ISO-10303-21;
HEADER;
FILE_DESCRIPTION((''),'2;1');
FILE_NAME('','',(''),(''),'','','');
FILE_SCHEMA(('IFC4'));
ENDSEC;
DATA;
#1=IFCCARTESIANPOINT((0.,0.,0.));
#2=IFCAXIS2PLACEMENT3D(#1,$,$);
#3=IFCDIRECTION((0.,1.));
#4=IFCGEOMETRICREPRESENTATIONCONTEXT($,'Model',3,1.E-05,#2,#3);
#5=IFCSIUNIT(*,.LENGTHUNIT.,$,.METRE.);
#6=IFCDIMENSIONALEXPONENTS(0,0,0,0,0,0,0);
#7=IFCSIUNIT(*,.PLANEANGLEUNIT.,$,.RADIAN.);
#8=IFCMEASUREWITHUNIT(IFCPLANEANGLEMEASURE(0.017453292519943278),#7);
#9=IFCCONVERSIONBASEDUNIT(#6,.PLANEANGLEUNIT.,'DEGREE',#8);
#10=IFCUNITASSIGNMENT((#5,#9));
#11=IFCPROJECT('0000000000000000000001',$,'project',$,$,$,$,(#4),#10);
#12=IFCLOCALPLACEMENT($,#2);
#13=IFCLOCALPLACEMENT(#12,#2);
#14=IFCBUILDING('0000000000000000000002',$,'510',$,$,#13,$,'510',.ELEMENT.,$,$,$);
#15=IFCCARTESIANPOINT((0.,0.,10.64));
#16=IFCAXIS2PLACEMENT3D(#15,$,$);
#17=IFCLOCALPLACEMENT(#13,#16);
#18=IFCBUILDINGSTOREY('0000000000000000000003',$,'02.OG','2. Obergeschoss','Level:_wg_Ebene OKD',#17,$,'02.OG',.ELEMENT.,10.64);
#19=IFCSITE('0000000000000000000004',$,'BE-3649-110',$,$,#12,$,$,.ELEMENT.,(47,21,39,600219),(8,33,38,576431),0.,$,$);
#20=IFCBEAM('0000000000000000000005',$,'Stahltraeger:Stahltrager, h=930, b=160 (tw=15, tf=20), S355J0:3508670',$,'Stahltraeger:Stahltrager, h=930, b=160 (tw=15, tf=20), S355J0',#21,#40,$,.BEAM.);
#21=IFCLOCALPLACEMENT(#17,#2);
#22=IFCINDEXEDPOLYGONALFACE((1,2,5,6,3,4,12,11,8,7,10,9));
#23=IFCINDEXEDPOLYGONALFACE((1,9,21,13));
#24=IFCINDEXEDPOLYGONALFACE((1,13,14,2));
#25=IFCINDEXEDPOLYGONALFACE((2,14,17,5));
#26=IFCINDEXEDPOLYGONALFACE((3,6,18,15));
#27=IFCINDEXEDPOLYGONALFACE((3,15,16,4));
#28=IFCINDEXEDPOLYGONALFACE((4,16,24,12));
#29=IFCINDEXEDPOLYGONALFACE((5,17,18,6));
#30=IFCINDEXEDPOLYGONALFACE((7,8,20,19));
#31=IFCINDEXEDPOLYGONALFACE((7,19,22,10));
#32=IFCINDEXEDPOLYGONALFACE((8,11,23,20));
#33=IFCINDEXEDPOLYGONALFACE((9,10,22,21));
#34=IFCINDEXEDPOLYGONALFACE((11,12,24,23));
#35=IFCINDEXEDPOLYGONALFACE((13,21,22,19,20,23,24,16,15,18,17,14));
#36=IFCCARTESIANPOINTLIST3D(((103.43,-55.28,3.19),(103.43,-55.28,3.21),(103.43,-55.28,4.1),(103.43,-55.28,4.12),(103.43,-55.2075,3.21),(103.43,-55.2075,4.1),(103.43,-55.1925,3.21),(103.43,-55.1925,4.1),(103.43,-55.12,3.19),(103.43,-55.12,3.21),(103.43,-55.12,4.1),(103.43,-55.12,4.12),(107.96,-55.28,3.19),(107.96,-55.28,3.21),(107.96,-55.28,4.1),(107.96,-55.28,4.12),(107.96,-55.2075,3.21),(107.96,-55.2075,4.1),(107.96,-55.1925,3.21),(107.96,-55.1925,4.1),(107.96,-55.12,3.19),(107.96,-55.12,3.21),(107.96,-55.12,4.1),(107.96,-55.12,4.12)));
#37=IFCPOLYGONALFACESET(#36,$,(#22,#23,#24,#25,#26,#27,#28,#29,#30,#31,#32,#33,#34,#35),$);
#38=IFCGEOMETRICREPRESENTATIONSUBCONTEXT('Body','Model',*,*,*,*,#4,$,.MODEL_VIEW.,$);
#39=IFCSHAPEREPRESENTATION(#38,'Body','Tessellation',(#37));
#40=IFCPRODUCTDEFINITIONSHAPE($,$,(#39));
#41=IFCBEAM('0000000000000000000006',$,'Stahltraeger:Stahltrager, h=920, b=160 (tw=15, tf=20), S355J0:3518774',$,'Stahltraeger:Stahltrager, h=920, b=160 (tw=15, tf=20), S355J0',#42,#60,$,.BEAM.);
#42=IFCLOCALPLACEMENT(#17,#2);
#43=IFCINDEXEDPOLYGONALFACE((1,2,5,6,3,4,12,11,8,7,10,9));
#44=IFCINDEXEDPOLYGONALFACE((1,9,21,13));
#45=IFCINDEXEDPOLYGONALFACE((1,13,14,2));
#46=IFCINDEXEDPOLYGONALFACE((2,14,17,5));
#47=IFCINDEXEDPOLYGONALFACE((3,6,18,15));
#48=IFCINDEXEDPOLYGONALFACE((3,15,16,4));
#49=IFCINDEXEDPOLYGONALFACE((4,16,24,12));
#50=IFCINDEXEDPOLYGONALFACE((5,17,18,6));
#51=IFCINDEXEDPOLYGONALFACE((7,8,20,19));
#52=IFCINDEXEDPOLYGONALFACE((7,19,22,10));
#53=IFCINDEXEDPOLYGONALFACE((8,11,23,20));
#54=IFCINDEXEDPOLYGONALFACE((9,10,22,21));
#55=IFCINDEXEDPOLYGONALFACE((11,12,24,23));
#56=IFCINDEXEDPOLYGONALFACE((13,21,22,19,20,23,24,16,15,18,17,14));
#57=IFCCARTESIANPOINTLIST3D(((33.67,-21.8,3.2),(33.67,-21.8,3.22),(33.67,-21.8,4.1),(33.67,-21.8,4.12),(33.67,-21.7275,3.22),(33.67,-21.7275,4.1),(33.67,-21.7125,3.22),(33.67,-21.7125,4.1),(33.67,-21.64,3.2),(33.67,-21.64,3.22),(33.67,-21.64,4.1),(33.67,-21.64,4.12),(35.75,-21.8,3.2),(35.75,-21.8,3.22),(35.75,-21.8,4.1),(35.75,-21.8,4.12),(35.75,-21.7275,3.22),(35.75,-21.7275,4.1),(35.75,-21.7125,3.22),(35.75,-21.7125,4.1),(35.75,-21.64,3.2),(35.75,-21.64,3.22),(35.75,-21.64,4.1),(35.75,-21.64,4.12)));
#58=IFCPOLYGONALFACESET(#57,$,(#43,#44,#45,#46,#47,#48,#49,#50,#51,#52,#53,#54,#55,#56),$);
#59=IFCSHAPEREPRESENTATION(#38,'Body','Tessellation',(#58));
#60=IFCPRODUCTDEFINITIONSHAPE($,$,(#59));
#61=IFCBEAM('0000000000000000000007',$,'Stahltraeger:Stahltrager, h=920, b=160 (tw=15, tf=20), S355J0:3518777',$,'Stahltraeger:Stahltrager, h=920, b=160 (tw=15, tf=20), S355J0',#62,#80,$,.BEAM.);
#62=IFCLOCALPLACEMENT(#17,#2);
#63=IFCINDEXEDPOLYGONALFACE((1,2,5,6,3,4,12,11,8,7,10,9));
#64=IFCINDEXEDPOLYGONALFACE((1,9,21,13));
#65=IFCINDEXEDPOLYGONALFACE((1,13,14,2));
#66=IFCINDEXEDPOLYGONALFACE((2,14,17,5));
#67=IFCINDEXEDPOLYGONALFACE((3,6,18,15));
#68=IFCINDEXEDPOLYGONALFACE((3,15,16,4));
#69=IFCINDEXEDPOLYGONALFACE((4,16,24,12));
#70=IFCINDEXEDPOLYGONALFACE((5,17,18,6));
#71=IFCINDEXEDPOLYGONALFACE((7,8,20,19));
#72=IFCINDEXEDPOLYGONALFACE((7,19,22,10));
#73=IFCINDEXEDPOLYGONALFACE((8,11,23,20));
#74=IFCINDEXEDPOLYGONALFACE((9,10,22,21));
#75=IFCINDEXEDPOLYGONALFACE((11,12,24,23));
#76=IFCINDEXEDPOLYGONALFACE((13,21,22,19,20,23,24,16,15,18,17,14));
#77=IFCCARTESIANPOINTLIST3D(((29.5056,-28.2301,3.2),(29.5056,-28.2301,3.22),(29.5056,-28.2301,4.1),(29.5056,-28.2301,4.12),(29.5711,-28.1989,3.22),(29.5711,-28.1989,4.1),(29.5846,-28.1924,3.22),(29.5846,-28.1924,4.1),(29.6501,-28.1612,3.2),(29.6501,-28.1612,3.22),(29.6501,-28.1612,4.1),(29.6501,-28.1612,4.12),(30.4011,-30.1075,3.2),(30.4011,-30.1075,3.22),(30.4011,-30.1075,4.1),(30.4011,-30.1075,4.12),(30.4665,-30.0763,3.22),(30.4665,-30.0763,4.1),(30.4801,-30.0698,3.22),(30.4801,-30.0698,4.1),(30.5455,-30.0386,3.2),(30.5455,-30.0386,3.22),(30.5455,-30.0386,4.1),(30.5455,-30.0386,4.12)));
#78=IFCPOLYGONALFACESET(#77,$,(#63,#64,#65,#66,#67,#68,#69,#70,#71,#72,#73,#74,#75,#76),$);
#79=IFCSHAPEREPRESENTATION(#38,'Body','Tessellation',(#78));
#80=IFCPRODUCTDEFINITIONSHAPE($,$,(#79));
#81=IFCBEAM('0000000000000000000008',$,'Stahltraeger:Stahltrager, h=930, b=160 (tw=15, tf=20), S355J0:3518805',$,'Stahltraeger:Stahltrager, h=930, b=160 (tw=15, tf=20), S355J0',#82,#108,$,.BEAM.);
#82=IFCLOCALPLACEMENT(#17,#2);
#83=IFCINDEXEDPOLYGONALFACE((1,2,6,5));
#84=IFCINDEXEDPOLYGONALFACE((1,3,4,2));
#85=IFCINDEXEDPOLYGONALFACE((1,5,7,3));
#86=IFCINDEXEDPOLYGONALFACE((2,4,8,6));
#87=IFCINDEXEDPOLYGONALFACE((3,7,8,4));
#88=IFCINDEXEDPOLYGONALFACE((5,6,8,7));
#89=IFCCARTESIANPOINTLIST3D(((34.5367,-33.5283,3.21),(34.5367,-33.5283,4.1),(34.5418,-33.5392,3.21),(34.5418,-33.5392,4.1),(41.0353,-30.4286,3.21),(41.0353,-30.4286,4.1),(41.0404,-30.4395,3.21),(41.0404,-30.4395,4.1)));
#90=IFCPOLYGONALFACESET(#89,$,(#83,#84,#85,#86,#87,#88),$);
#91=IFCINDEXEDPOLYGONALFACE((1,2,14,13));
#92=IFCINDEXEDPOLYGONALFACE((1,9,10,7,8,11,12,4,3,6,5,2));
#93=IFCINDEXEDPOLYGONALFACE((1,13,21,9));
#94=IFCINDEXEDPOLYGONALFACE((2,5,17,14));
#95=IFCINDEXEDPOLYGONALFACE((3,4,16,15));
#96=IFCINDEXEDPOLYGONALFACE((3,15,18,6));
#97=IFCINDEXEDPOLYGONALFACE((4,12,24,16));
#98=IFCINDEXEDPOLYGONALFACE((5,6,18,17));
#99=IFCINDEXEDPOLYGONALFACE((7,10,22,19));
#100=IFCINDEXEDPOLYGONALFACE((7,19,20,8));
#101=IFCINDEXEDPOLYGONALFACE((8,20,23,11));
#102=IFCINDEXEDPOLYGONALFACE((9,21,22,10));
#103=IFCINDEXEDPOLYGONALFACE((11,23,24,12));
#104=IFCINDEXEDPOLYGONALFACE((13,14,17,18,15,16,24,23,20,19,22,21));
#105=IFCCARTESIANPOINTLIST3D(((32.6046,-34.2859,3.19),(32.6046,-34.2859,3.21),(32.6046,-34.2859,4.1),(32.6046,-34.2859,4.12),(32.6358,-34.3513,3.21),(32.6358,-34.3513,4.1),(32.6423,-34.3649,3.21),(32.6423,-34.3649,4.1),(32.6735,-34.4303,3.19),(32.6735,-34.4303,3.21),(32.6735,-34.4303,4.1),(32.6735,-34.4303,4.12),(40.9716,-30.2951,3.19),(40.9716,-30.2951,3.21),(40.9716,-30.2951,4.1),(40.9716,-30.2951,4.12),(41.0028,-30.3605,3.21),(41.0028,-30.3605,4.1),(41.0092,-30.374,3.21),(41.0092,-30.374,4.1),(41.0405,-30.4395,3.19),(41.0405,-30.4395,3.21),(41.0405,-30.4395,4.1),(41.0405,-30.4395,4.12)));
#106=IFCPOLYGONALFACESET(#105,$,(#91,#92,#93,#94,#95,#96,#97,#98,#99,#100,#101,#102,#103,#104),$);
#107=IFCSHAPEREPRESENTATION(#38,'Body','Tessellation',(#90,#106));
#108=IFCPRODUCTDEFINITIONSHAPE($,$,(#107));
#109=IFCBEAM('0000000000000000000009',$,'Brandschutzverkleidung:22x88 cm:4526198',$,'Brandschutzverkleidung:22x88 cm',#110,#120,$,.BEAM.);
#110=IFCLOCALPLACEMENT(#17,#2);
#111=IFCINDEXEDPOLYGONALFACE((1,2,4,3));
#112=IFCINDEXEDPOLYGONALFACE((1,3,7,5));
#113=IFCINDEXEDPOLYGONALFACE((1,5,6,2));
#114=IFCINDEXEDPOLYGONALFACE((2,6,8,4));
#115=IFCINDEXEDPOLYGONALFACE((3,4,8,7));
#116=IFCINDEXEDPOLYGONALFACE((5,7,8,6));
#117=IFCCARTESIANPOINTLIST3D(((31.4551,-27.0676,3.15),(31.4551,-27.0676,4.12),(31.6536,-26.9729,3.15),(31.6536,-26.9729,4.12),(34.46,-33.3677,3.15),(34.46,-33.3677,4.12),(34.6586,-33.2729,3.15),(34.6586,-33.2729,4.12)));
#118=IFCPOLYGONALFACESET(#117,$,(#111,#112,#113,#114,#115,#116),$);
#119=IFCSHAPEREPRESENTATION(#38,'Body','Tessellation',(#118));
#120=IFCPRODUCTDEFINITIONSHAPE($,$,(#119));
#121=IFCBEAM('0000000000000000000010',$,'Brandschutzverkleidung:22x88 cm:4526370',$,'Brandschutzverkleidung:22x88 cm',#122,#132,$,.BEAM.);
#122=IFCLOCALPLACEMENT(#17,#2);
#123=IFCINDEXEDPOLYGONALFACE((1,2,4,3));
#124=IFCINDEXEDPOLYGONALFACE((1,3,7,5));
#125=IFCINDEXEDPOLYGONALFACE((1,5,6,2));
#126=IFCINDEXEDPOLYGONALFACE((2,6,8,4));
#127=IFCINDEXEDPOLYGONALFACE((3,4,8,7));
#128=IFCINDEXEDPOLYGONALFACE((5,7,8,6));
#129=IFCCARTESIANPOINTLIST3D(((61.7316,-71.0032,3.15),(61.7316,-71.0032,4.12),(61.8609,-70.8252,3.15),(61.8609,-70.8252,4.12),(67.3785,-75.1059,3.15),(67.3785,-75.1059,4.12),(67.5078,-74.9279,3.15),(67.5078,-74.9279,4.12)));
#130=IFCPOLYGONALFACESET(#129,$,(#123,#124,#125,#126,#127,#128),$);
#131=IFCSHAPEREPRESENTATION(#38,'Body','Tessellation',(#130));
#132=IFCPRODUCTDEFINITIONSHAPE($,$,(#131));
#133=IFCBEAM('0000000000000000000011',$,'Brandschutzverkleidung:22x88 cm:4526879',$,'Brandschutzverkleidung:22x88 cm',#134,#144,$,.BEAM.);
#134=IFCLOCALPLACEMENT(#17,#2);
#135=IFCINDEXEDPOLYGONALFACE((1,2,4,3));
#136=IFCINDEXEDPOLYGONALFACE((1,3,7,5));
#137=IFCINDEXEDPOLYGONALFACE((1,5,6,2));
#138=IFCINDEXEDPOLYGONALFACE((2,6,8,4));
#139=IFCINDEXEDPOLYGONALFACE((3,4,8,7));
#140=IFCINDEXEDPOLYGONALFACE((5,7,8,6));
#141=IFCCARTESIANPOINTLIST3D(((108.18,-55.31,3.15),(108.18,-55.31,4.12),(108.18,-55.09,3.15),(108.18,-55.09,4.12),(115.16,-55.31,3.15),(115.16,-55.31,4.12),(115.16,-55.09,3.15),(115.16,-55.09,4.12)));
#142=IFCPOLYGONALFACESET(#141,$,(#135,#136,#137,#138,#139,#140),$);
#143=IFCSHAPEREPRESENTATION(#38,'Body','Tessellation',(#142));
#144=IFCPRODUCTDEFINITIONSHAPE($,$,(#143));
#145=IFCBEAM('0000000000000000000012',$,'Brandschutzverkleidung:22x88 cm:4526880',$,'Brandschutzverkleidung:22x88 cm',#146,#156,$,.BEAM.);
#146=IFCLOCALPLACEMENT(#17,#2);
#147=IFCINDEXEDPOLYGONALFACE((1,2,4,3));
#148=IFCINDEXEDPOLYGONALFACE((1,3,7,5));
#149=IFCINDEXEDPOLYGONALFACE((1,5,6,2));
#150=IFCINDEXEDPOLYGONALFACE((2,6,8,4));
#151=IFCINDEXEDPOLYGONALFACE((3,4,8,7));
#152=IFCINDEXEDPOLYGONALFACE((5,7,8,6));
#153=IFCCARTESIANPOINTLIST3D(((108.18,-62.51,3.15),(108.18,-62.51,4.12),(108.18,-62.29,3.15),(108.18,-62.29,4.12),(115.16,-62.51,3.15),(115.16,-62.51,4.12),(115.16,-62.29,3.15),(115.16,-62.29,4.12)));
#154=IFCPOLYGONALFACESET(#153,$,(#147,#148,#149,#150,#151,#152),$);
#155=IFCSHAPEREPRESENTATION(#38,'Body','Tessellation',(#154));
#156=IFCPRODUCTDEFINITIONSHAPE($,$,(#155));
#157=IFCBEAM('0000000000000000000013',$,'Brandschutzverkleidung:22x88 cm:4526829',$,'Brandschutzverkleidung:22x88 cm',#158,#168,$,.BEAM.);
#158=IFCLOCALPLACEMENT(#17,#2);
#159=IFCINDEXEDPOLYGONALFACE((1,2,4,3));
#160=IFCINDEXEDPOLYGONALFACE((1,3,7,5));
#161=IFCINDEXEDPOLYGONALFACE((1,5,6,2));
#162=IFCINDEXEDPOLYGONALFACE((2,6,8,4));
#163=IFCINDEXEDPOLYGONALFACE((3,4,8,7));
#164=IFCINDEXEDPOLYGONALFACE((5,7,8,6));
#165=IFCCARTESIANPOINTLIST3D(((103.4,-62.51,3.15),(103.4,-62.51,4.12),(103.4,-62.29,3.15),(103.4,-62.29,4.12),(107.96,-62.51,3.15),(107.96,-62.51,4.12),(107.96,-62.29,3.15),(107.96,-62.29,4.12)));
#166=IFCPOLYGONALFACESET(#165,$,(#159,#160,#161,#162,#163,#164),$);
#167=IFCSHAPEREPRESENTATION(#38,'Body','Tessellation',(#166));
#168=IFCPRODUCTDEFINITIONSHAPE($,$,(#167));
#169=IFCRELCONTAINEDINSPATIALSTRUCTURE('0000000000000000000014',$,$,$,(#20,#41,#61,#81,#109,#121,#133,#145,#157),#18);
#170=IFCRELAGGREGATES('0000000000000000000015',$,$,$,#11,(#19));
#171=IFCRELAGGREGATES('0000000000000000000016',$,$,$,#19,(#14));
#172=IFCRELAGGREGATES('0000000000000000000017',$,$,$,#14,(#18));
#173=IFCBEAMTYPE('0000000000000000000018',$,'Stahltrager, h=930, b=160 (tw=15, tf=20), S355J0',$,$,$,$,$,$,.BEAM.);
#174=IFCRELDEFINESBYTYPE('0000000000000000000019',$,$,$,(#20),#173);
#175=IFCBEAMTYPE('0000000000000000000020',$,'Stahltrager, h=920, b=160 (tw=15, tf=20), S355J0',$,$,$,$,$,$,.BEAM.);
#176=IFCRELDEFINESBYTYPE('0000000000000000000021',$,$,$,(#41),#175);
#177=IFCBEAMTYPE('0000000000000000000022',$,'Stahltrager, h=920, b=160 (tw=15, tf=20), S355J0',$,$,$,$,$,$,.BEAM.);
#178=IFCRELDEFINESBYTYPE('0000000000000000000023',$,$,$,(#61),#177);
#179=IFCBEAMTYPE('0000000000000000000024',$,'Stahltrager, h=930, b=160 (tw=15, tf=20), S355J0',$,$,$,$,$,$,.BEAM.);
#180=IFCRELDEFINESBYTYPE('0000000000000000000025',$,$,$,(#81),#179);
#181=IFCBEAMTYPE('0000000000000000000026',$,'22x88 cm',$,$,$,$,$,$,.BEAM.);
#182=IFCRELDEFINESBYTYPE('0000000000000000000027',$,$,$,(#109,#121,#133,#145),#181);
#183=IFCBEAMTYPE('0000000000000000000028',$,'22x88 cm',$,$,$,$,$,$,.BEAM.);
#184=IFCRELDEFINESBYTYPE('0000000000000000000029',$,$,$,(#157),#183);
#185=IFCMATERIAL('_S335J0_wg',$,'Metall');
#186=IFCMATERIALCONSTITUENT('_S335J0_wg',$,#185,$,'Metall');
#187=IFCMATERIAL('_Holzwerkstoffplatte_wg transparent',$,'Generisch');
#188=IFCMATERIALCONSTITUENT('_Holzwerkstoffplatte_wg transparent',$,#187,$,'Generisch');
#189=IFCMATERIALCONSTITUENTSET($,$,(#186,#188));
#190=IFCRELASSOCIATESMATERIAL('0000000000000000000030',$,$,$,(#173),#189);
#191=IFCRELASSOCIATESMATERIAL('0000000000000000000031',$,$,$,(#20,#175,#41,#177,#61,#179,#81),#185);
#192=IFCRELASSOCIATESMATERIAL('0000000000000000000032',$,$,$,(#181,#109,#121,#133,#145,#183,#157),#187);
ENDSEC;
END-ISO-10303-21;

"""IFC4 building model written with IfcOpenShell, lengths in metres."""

from ifc_helpers import new_model, entity, si_unit, converted_unit, direction, frame, origin, place, context, subcontext, project, spatial, indexed_curve, outline, extrude, source, transform, mapped, material, constituent, constituent_set, type_object, type_shapes, element, save


model = new_model("IFC4")

# Units and contexts
model_context = context("Model", 3, precision=1e-05, world=origin(), true_north=direction((0.0, 1.0)))
body_context = subcontext(model_context, "Body", "Model", "MODEL_VIEW")
ifc_project = project(units=[si_unit("LENGTHUNIT", "METRE"), converted_unit("PLANEANGLEUNIT", "DEGREE", entity("IfcPlaneAngleMeasure", 0.017453292519943278), si_unit("PLANEANGLEUNIT", "RADIAN"), dimensions=[0, 0, 0, 0, 0, 0, 0])], contexts=[model_context])

# Site, building, storey
site_placement = place(None, origin())
site = spatial("IfcSite", under=ifc_project, at=site_placement, Name="BE-3649-110", CompositionType="ELEMENT", RefLatitude=(47, 21, 39, 600219), RefLongitude=(8, 33, 38, 576431), RefElevation=0.0)
building_placement = place(site_placement, origin())
building = spatial("IfcBuilding", under=site, at=building_placement, Name="510", LongName="510", CompositionType="ELEMENT")
storey_placement = place(building_placement, frame((0.0, 0.0, 10.64)))
storey = spatial("IfcBuildingStorey", under=building, at=storey_placement, Name="02.OG", Description="2. Obergeschoss", ObjectType="Level:_wg_Ebene OKD", LongName="02.OG", CompositionType="ELEMENT", Elevation=10.64)

# Shared definitions
ifc_material_1 = material(Name="_S335J0_wg", Category="Metall")

# Shared definitions
ifc_material_2 = material(Name="_Holzwerkstoffplatte_wg transparent", Category="Generisch")

# Beam
ifc_constituent_1 = constituent(ifc_material_1, Name="_S335J0_wg", Category="Metall")
ifc_constituent_2 = constituent(ifc_material_2, Name="_Holzwerkstoffplatte_wg transparent", Category="Generisch")
ifc_constituent_set_1 = constituent_set(constituents=[ifc_constituent_1, ifc_constituent_2])
beam_type_1 = type_object("IfcBeamType", Name="Stahltrager, h=930, b=160 (tw=15, tf=20), S355J0", PredefinedType="BEAM", material=ifc_constituent_set_1)
shared_shape_1 = source(origin(), body_context, "Body", "SweptSolid", [
    extrude(outline(indexed_curve([(-0.465, -0.08), (-0.445, -0.08), (-0.445, -0.0075), (0.445, -0.0075), (0.445, -0.08), (0.465, -0.08), (0.465, 0.08), (0.445, 0.08), (0.445, 0.0075), (-0.445, 0.0075), (-0.445, 0.08), (-0.465, 0.08), (-0.465, -0.08)], self_intersect=False)), frame((-2.265, 0.0, 0.0), z_axis=(1.0, 0.0, 0.0), x_axis=(0.0, 0.0, -1.0)), (0.0, 0.0, 1.0), 4.53),
])
type_shapes(beam_type_1, [shared_shape_1])
beam_1_placement = place(storey_placement, frame((105.695, -55.2, 3.655)))
element("IfcBeam", 1, at=beam_1_placement, inside=storey, type_object=beam_type_1, material=ifc_material_1, Name="Stahltraeger:Stahltrager, h=930, b=160 (tw=15, tf=20), S355J0:3508670", ObjectType="Stahltraeger:Stahltrager, h=930, b=160 (tw=15, tf=20), S355J0", PredefinedType="BEAM", context=body_context, shape_type="MappedRepresentation", body=[
    mapped(shared_shape_1, transform((0.0, 0.0, 0.0), scale=1.0)),
])

# Beams, openings
beam_type_2 = type_object("IfcBeamType", Name="Stahltrager, h=920, b=160 (tw=15, tf=20), S355J0", PredefinedType="BEAM", material=ifc_material_1)
shared_shape_2 = source(origin(), body_context, "Body", "SweptSolid", [
    extrude(outline(indexed_curve([(-0.08, -0.44), (-0.08, -0.46), (0.08, -0.46), (0.08, -0.44), (0.0075, -0.44), (0.0075, 0.44), (0.08, 0.44), (0.08, 0.46), (-0.08, 0.46), (-0.08, 0.44), (-0.0075, 0.44), (-0.0075, -0.44), (-0.08, -0.44)], self_intersect=False)), frame((0.0, 0.08, 0.46), z_axis=(-1.0, 0.0, 0.0), x_axis=(0.0, -1.0, 0.0)), (0.0, 0.0, -1.0), 2.08),
])
type_shapes(beam_type_2, [shared_shape_2])
beam_2_placement = place(storey_placement, frame((33.67, -21.8, 3.2)))
beam_2 = element("IfcBeam", 2, at=beam_2_placement, inside=storey, type_object=beam_type_2, material=ifc_material_1, Name="Stahltraeger:Stahltrager, h=920, b=160 (tw=15, tf=20), S355J0:3518774", ObjectType="Stahltraeger:Stahltrager, h=920, b=160 (tw=15, tf=20), S355J0", PredefinedType="BEAM", context=body_context, shape_type="MappedRepresentation", body=[
    mapped(shared_shape_2, transform((0.0, 0.0, 0.0), scale=1.0)),
])
opening_1_placement = place(storey_placement, frame((33.67, -21.8, 3.2)))
element("IfcOpeningElement", 3, at=opening_1_placement, cuts=beam_2, PredefinedType="OPENING", context=body_context, shape_type="SweptSolid", body=[
    extrude(outline(indexed_curve([(-0.32, -0.22), (0.32, -0.22), (0.32, 0.22), (-0.32, 0.22), (-0.32, -0.22)], self_intersect=False)), frame((1.3687, 0.0875, -10.2), z_axis=(0.0, -1.0, 0.0), x_axis=(1.0, 0.0, 0.0)), (0.0, 0.0, 1.0), 0.015),
])
beam_type_3 = type_object("IfcBeamType", Name="Stahltrager, h=920, b=160 (tw=15, tf=20), S355J0", PredefinedType="BEAM", material=ifc_material_1)
shared_shape_3 = source(origin(), body_context, "Body", "SweptSolid", [
    extrude(outline(indexed_curve([(-0.08, -0.44), (-0.08, -0.46), (0.08, -0.46), (0.08, -0.44), (0.0075, -0.44), (0.0075, 0.44), (0.08, 0.44), (0.08, 0.46), (-0.08, 0.46), (-0.08, 0.44), (-0.0075, 0.44), (-0.0075, -0.44), (-0.08, -0.44)], self_intersect=False)), frame((0.9677, 0.0344, 0.46), z_axis=(0.430511, -0.902585, 0.0), x_axis=(0.902585, 0.430511, 0.0)), (0.0, 0.0, -1.0), 2.08),
])
type_shapes(beam_type_3, [shared_shape_3])
beam_3_placement = place(storey_placement, frame((29.5056, -30.1075, 3.2)))
beam_3 = element("IfcBeam", 4, at=beam_3_placement, inside=storey, type_object=beam_type_3, material=ifc_material_1, Name="Stahltraeger:Stahltrager, h=920, b=160 (tw=15, tf=20), S355J0:3518777", ObjectType="Stahltraeger:Stahltrager, h=920, b=160 (tw=15, tf=20), S355J0", PredefinedType="BEAM", context=body_context, shape_type="MappedRepresentation", body=[
    mapped(shared_shape_3, transform((0.0, 0.0, 0.0), scale=1.0)),
])
opening_2_placement = place(storey_placement, frame((29.5056, -30.1075, 3.2)))
element("IfcOpeningElement", 5, at=opening_2_placement, cuts=beam_3, PredefinedType="OPENING", context=body_context, shape_type="SweptSolid", body=[
    extrude(outline(indexed_curve([(-0.32, -0.22), (0.32, -0.22), (0.32, 0.22), (-0.32, 0.22), (-0.32, -0.22)], self_intersect=False)), frame((0.5132, 0.9699, -10.2), z_axis=(0.902585, 0.430511, 0.0), x_axis=(-0.430511, 0.902585, 0.0)), (0.0, 0.0, 1.0), 0.015),
])
beam_type_4 = type_object("IfcBeamType", Name="Stahltrager, h=930, b=160 (tw=15, tf=20), S355J0", PredefinedType="BEAM", material=ifc_material_1)
shared_shape_4 = source(origin(), body_context, "Body", "SweptSolid", [
    extrude(outline(indexed_curve([(-0.445, -0.006), (0.445, -0.006), (0.445, 0.006), (-0.445, 0.006), (-0.445, -0.006)], self_intersect=False)), frame((1.9346, 0.8966, 0.465), z_axis=(0.902585, 0.430511, 0.0), x_axis=(0.0, 0.0, -1.0)), (0.0, 0.0, 1.0), 7.2),
    extrude(outline(indexed_curve([(0.445, -0.08), (0.465, -0.08), (0.465, 0.08), (0.445, 0.08), (0.445, 0.0075), (-0.445, 0.0075), (-0.445, 0.08), (-0.465, 0.08), (-0.465, -0.08), (-0.445, -0.08), (-0.445, -0.0075), (0.445, -0.0075), (0.445, -0.08)], self_intersect=False)), frame((0.0344, 0.0722, 0.465), z_axis=(0.902585, 0.430511, 0.0), x_axis=(0.0, 0.0, -1.0)), (0.0, 0.0, 1.0), 9.27),
])
type_shapes(beam_type_4, [shared_shape_4])
beam_4_placement = place(storey_placement, frame((32.6046, -34.4303, 3.19)))
beam_4 = element("IfcBeam", 6, at=beam_4_placement, inside=storey, type_object=beam_type_4, material=ifc_material_1, Name="Stahltraeger:Stahltrager, h=930, b=160 (tw=15, tf=20), S355J0:3518805", ObjectType="Stahltraeger:Stahltrager, h=930, b=160 (tw=15, tf=20), S355J0", PredefinedType="BEAM", context=body_context, shape_type="MappedRepresentation", body=[
    mapped(shared_shape_4, transform((0.0, 0.0, 0.0), scale=1.0)),
])
opening_3_placement = place(storey_placement, frame((32.6046, -34.4303, 3.19)))
element("IfcOpeningElement", 7, at=opening_3_placement, cuts=beam_4, PredefinedType="OPENING", context=body_context, shape_type="SweptSolid", body=[
    extrude(outline(indexed_curve([(-0.225, -0.15), (0.225, -0.15), (0.225, 0.15), (-0.225, 0.15), (-0.225, -0.15)], self_intersect=False)), frame((0.9703, 0.5103, -10.1928), z_axis=(-0.430511, 0.902585, 0.0), x_axis=(-0.902585, -0.430511, 0.0)), (0.0, 0.0, 1.0), 0.015),
])

# Beams
beam_type_5 = type_object("IfcBeamType", Name="22x88 cm", PredefinedType="BEAM", material=ifc_material_2)
shared_shape_5 = source(origin(), body_context, "Body", "SweptSolid", [
    extrude(outline(indexed_curve([(-3.49, -0.11), (3.49, -0.11), (3.49, 0.11), (-3.49, 0.11), (-3.49, -0.11)], self_intersect=False)), frame((0.0, 0.0, -0.485)), (0.0, 0.0, 1.0), 0.97),
])
type_shapes(beam_type_5, [shared_shape_5])
for number, where, z_axis, x_axis, name in (
    (8, (33.0568, -30.1703, 3.635), (0.0, 0.0, 1.0), (0.430511, -0.902585, 0.0), "Brandschutzverkleidung:22x88 cm:4526198"),
    (9, (64.6197, -72.9655, 3.635), (0.0, 0.0, 1.0), (0.809017, -0.587785, 0.0), "Brandschutzverkleidung:22x88 cm:4526370"),
):
    element("IfcBeam", number, at=place(storey_placement, frame(where, z_axis=z_axis, x_axis=x_axis)), inside=storey, type_object=beam_type_5, material=ifc_material_2, Name=name, ObjectType="Brandschutzverkleidung:22x88 cm", PredefinedType="BEAM", context=body_context, shape_type="MappedRepresentation", body=[
        mapped(shared_shape_5, transform((0.0, 0.0, 0.0), scale=1.0)),
    ])
for number, where, name in (
    (10, (111.67, -55.2, 3.635), "Brandschutzverkleidung:22x88 cm:4526879"),
    (11, (111.67, -62.4, 3.635), "Brandschutzverkleidung:22x88 cm:4526880"),
):
    element("IfcBeam", number, at=place(storey_placement, frame(where)), inside=storey, type_object=beam_type_5, material=ifc_material_2, Name=name, ObjectType="Brandschutzverkleidung:22x88 cm", PredefinedType="BEAM", context=body_context, shape_type="MappedRepresentation", body=[
        mapped(shared_shape_5, transform((0.0, 0.0, 0.0), scale=1.0)),
    ])
beam_type_6 = type_object("IfcBeamType", Name="22x88 cm", PredefinedType="BEAM", material=ifc_material_2)
shared_shape_6 = source(origin(), body_context, "Body", "SweptSolid", [
    extrude(outline(indexed_curve([(-2.28, -0.11), (2.28, -0.11), (2.28, 0.11), (-2.28, 0.11), (-2.28, -0.11)], self_intersect=False)), frame((0.0, 0.0, -0.485)), (0.0, 0.0, 1.0), 0.97),
])
type_shapes(beam_type_6, [shared_shape_6])
beam_5_placement = place(storey_placement, frame((105.68, -62.4, 3.635)))
element("IfcBeam", 12, at=beam_5_placement, inside=storey, type_object=beam_type_6, material=ifc_material_2, Name="Brandschutzverkleidung:22x88 cm:4526829", ObjectType="Brandschutzverkleidung:22x88 cm", PredefinedType="BEAM", context=body_context, shape_type="MappedRepresentation", body=[
    mapped(shared_shape_6, transform((0.0, 0.0, 0.0), scale=1.0)),
])

save(model, "model.ifc")
